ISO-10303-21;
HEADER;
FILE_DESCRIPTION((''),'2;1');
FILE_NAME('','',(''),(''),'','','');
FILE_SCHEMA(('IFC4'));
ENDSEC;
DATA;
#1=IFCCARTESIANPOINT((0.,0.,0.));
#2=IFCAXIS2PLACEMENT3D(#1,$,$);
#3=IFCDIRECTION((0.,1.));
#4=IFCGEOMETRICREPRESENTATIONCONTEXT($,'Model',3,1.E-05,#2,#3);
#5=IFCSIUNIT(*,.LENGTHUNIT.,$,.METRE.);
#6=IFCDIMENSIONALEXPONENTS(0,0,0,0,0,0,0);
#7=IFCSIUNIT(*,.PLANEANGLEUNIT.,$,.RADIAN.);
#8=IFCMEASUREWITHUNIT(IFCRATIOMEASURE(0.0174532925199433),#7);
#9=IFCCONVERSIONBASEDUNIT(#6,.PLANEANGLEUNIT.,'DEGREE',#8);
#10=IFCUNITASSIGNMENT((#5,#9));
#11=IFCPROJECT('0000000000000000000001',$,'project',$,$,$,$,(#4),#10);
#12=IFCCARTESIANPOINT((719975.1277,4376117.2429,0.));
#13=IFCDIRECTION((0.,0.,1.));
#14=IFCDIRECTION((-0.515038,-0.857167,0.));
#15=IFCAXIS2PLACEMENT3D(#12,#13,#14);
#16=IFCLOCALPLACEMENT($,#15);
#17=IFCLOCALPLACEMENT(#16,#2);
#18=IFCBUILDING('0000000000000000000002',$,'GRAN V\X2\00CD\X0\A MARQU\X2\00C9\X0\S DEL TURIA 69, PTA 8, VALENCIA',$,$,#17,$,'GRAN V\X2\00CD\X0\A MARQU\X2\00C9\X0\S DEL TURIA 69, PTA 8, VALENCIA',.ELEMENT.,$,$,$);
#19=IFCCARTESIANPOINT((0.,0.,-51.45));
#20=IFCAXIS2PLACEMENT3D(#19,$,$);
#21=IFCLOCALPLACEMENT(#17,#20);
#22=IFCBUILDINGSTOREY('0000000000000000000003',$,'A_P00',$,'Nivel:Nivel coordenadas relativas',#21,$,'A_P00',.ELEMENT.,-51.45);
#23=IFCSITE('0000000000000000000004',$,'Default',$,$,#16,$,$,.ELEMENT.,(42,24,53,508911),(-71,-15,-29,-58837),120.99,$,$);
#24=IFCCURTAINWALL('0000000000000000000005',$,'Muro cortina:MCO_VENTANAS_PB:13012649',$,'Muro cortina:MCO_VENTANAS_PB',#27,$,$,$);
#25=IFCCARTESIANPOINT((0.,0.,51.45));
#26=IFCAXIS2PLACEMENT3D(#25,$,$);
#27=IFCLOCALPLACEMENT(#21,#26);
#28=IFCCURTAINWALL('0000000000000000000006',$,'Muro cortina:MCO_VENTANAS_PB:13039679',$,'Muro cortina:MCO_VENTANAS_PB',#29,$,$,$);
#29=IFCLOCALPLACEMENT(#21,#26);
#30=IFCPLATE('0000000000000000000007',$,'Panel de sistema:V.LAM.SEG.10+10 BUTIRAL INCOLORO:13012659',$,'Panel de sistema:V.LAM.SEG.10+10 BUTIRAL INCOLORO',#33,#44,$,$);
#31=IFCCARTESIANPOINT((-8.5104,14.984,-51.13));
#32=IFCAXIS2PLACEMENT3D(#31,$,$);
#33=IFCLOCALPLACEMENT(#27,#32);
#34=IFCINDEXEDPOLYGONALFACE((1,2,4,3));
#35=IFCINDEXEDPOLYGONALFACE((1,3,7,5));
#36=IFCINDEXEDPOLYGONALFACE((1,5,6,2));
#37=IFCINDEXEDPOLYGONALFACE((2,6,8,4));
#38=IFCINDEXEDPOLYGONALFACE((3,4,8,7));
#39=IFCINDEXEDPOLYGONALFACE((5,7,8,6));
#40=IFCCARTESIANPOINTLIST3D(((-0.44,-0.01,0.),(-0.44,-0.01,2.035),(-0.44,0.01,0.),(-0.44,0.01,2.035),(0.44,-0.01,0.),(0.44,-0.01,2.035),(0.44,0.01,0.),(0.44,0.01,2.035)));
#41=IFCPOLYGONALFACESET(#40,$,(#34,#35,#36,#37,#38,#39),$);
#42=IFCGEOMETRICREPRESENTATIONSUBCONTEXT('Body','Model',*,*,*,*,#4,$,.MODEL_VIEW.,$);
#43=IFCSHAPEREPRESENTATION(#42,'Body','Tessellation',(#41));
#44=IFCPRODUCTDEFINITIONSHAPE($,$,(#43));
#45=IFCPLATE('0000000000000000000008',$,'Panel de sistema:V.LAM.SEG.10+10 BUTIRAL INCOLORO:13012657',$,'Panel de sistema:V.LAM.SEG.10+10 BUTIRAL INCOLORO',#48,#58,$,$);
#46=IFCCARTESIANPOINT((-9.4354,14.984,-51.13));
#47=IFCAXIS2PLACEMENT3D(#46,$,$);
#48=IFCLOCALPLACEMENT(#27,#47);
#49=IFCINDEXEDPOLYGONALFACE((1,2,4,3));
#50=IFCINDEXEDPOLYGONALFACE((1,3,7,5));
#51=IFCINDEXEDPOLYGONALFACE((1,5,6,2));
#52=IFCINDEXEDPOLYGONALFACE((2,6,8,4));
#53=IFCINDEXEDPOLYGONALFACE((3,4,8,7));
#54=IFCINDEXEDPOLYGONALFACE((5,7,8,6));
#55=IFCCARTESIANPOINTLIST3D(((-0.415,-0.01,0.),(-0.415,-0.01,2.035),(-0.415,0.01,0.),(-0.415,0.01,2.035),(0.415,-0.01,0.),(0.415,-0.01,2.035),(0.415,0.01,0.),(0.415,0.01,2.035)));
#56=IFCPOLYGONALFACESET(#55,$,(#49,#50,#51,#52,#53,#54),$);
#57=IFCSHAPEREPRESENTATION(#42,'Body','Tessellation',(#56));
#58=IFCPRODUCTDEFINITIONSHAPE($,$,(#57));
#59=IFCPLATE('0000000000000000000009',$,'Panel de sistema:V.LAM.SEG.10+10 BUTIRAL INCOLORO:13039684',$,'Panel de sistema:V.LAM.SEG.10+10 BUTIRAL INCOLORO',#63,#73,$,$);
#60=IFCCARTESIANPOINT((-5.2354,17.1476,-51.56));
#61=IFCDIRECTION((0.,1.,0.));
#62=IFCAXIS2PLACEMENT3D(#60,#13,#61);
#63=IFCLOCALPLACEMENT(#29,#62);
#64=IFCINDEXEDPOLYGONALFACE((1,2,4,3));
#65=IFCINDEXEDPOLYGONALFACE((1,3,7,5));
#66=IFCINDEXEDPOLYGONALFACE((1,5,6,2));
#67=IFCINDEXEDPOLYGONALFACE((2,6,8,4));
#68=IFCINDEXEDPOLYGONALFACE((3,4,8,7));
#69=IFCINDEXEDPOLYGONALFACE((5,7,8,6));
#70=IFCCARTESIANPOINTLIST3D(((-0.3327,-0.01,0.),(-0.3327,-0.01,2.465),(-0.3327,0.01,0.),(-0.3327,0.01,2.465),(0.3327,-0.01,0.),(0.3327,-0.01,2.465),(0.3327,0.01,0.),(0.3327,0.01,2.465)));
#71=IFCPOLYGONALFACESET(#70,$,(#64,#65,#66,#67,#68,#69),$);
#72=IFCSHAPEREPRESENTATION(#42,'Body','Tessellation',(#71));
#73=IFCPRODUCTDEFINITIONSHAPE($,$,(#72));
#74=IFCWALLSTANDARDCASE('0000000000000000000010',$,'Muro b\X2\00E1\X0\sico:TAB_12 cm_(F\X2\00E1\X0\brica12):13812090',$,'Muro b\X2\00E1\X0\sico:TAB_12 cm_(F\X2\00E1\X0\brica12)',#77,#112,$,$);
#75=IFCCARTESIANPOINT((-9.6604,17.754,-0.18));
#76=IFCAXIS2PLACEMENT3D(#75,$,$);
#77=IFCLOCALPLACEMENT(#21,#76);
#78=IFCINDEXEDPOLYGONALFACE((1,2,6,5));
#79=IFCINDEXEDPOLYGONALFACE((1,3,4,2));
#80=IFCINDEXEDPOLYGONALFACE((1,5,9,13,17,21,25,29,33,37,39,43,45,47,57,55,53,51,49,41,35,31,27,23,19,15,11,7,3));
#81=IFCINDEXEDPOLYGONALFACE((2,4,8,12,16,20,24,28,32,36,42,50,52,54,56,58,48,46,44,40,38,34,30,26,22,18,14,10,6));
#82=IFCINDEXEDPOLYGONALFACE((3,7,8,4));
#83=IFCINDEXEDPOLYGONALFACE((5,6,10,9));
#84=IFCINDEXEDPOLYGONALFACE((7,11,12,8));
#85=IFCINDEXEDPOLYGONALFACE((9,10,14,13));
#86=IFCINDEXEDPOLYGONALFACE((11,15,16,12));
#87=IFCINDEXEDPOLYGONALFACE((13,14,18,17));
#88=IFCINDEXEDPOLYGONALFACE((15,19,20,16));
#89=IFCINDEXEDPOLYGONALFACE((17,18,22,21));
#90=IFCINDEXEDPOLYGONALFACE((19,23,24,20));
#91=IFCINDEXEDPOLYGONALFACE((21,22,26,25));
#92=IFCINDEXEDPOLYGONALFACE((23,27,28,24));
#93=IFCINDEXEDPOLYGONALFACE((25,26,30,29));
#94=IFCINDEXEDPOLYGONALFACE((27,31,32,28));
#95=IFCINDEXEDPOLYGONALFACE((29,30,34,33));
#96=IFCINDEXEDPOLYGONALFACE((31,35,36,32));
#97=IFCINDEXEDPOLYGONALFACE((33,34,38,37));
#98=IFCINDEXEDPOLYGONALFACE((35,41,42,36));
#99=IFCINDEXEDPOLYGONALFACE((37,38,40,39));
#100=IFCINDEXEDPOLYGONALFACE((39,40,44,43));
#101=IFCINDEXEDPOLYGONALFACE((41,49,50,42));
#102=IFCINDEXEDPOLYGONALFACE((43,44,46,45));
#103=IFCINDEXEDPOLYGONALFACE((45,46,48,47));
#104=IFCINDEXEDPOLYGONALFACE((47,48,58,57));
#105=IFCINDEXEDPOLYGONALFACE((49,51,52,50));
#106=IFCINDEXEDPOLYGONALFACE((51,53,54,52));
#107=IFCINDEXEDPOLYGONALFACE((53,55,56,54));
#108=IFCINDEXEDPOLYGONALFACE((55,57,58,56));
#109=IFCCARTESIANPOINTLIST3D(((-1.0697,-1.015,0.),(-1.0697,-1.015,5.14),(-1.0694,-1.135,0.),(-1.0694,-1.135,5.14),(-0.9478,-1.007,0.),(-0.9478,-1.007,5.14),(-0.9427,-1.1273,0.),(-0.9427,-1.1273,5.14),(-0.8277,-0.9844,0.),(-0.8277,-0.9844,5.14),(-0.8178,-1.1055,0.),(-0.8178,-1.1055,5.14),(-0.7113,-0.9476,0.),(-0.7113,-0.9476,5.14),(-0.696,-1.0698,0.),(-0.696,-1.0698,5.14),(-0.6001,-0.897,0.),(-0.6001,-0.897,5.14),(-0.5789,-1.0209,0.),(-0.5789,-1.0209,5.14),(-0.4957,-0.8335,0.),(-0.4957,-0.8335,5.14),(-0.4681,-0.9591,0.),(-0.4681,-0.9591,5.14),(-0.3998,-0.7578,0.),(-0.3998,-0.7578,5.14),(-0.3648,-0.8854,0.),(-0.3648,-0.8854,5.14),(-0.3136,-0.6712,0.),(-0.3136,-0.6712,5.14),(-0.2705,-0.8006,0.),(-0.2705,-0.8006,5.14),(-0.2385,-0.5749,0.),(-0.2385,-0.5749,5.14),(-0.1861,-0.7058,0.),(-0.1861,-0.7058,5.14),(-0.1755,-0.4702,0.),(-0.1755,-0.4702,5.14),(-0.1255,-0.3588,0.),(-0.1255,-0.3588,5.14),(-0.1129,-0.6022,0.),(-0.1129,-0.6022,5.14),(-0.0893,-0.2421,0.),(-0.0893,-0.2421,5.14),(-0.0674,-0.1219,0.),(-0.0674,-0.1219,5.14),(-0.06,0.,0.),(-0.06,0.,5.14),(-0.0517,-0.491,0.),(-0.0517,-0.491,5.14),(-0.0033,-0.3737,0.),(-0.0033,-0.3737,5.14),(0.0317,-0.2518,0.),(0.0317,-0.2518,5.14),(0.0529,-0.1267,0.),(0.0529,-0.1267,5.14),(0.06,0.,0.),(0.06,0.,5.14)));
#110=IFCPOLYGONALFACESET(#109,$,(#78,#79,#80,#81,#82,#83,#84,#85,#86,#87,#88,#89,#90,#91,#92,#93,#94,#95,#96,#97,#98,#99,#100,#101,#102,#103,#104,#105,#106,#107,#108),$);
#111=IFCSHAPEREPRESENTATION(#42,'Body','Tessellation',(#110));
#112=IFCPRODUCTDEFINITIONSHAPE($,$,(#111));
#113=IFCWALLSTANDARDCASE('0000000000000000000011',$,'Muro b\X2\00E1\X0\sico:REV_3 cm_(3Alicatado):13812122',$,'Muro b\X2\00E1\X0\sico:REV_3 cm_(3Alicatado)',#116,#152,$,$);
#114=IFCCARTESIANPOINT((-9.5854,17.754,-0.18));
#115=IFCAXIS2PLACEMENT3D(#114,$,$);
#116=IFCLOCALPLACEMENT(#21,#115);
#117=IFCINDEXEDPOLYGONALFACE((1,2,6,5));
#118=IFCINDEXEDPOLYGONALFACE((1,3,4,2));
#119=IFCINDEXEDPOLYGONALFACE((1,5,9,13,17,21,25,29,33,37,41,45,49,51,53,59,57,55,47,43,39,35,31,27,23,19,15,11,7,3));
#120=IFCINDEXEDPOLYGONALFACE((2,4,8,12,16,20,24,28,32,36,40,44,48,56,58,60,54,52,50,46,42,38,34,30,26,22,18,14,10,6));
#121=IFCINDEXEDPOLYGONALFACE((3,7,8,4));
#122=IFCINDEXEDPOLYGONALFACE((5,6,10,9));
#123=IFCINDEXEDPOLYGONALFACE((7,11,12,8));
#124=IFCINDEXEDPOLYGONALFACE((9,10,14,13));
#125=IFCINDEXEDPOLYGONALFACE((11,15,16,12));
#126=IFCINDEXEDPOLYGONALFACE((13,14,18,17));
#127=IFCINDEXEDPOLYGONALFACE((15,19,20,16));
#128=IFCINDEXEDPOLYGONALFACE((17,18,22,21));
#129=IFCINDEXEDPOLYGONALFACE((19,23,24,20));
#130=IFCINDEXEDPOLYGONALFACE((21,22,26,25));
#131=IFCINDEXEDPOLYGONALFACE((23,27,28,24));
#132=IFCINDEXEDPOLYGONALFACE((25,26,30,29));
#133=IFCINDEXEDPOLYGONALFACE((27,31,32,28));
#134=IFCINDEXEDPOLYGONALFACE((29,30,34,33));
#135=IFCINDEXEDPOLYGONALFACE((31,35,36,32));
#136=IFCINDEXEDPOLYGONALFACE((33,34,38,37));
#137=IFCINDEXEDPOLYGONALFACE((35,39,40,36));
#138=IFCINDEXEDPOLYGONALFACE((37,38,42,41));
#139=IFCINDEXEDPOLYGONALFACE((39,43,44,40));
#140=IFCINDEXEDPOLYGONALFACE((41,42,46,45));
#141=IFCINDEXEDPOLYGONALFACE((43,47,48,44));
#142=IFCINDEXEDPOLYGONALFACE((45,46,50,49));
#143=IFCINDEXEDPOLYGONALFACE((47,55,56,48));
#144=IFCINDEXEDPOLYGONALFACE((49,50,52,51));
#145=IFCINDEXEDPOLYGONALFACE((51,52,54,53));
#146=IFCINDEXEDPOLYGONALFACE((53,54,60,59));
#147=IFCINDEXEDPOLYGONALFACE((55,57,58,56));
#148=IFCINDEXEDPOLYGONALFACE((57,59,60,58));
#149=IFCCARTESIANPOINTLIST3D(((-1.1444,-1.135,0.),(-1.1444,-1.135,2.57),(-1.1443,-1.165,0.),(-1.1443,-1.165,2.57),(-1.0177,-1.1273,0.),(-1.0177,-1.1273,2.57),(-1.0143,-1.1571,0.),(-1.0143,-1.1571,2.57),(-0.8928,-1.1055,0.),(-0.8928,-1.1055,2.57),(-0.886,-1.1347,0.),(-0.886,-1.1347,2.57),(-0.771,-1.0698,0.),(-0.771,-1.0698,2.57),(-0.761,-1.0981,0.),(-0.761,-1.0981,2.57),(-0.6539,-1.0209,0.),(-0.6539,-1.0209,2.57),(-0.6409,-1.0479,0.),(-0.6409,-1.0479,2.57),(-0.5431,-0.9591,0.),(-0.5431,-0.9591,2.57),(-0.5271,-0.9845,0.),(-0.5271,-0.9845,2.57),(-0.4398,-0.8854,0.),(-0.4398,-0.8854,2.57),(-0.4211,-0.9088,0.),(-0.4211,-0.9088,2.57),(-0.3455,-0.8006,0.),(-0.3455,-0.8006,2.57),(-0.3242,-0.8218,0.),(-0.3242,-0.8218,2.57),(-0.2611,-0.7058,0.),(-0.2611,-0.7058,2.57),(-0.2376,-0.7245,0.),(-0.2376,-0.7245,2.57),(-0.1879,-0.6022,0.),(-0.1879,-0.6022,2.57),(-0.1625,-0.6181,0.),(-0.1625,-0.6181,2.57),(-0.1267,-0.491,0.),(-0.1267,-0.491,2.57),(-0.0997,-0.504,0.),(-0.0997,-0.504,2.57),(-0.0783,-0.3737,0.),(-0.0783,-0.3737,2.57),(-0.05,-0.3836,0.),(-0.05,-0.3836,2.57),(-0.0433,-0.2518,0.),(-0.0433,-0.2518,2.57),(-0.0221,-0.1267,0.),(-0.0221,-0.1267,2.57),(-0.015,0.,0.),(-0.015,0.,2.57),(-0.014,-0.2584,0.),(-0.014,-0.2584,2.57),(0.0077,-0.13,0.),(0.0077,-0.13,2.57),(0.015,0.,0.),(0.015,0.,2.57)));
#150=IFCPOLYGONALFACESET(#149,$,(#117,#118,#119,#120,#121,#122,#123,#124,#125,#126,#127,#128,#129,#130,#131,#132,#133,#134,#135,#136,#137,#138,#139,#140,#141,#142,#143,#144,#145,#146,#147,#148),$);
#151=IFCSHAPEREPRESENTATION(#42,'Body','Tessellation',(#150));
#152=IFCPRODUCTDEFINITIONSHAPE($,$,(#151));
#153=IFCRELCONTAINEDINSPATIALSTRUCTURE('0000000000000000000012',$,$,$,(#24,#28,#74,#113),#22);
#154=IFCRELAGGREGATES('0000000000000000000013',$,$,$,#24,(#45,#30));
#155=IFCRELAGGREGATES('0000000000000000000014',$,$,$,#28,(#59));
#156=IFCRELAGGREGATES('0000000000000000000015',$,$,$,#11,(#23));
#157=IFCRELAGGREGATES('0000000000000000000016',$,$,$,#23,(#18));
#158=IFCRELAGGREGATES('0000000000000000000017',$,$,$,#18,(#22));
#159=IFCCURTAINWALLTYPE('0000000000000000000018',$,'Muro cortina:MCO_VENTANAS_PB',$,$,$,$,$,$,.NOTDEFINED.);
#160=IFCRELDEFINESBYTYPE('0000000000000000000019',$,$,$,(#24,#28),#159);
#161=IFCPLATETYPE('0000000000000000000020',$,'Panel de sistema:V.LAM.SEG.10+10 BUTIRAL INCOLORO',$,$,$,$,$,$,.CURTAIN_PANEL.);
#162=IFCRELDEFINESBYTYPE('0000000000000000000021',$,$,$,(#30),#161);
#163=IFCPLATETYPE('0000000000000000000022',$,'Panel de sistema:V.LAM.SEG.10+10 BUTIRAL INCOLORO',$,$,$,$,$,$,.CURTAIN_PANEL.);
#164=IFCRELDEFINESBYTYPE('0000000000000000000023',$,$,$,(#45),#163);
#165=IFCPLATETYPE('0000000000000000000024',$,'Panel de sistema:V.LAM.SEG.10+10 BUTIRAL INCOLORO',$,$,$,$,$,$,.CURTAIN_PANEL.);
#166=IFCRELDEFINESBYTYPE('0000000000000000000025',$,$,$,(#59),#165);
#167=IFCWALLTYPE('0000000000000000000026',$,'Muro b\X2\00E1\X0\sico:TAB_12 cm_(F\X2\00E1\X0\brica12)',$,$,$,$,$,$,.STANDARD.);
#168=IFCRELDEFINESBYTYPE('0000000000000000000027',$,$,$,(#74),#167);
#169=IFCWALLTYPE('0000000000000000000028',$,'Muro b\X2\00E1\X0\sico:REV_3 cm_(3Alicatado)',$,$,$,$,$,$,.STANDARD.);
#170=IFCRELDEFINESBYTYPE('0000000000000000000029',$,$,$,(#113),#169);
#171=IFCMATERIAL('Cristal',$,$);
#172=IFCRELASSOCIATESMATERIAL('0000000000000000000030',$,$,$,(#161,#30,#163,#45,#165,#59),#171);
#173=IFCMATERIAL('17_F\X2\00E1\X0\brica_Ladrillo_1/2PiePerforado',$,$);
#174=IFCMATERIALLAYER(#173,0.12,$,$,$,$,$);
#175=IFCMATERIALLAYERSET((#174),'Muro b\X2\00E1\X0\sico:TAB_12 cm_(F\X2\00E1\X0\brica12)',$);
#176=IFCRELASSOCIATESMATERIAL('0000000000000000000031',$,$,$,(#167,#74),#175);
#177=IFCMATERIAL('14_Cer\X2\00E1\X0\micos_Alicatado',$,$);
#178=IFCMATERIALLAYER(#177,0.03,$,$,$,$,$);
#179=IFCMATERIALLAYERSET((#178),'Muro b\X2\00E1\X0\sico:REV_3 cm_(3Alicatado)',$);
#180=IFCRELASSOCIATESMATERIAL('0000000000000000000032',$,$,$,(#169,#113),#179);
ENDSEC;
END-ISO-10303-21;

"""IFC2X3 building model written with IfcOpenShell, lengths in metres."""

from ifc_helpers import new_model, entity, si_unit, converted_unit, direction, frame, frame_2d, origin, origin_2d_with_axis, place, context, subcontext, project, spatial, polyline, circle_curve, parameter, trimmed, segment, composite_curve, rectangle, outline, extrude, source, transform, mapped, material, layer, layer_set, layer_usage, type_object, type_shapes, element, aggregate, save


model = new_model("IFC2X3")

# Units and contexts
model_context = context("Model", 3, precision=1e-05, world=origin(), true_north=direction((0.0, 1.0)))
body_context = subcontext(model_context, "Body", "Model", "MODEL_VIEW")
ifc_project = project(units=[si_unit("LENGTHUNIT", "METRE"), converted_unit("PLANEANGLEUNIT", "DEGREE", entity("IfcRatioMeasure", 0.0174532925199433), si_unit("PLANEANGLEUNIT", "RADIAN"), dimensions=[0, 0, 0, 0, 0, 0, 0])], contexts=[model_context])

# Site, building, storey
site_placement = place(None, frame((719975.1277, 4376117.2429, 0.0), z_axis=(0.0, 0.0, 1.0), x_axis=(-0.515038, -0.857167, 0.0)))
site = spatial("IfcSite", under=ifc_project, at=site_placement, Name="Default", CompositionType="ELEMENT", RefLatitude=(42, 24, 53, 508911), RefLongitude=(-71, -15, -29, -58837), RefElevation=120.99)
building_placement = place(site_placement, origin())
building = spatial("IfcBuilding", under=site, at=building_placement, Name="GRAN VÍA MARQUÉS DEL TURIA 69, PTA 8, VALENCIA", LongName="GRAN VÍA MARQUÉS DEL TURIA 69, PTA 8, VALENCIA", CompositionType="ELEMENT")
storey_placement = place(building_placement, frame((0.0, 0.0, -51.45)))
storey = spatial("IfcBuildingStorey", under=building, at=storey_placement, Name="A_P00", ObjectType="Nivel:Nivel coordenadas relativas", LongName="A_P00", CompositionType="ELEMENT", Elevation=-51.45)

# Curtain walls
curtain_wall_type_1 = type_object("IfcCurtainWallType", Name="Muro cortina:MCO_VENTANAS_PB", PredefinedType="NOTDEFINED")
curtain_wall_1_placement = place(storey_placement, frame((0.0, 0.0, 51.45)))
curtain_wall_1 = element("IfcCurtainWall", 1, at=curtain_wall_1_placement, inside=storey, type_object=curtain_wall_type_1, Name="Muro cortina:MCO_VENTANAS_PB:13012649", ObjectType="Muro cortina:MCO_VENTANAS_PB")
curtain_wall_2_placement = place(storey_placement, frame((0.0, 0.0, 51.45)))
curtain_wall_2 = element("IfcCurtainWall", 2, at=curtain_wall_2_placement, inside=storey, type_object=curtain_wall_type_1, Name="Muro cortina:MCO_VENTANAS_PB:13039679", ObjectType="Muro cortina:MCO_VENTANAS_PB")

# Plates
ifc_material_1 = material(Name="Cristal")
plate_type_1 = type_object("IfcPlateType", Name="Panel de sistema:V.LAM.SEG.10+10 BUTIRAL INCOLORO", PredefinedType="CURTAIN_PANEL", material=ifc_material_1)
shared_shape_1 = source(origin(), body_context, "Body", "SweptSolid", [
    extrude(rectangle(XDim=0.02, YDim=0.88, at=origin_2d_with_axis()), frame((0.0, 0.0, 0.0), z_axis=(0.0, 0.0, 1.0), x_axis=(0.0, 1.0, 0.0)), (0.0, 0.0, 1.0), 2.035),
])
type_shapes(plate_type_1, [shared_shape_1])
plate_1_placement = place(curtain_wall_1_placement, frame((-8.5104, 14.984, -51.13)))
plate_1 = element("IfcPlate", 3, at=plate_1_placement, type_object=plate_type_1, material=ifc_material_1, Name="Panel de sistema:V.LAM.SEG.10+10 BUTIRAL INCOLORO:13012659", ObjectType="Panel de sistema:V.LAM.SEG.10+10 BUTIRAL INCOLORO", context=body_context, shape_type="MappedRepresentation", body=[
    mapped(shared_shape_1, transform((0.0, 0.0, 0.0), scale=1.0)),
])
plate_type_2 = type_object("IfcPlateType", Name="Panel de sistema:V.LAM.SEG.10+10 BUTIRAL INCOLORO", PredefinedType="CURTAIN_PANEL", material=ifc_material_1)
shared_shape_2 = source(origin(), body_context, "Body", "SweptSolid", [
    extrude(rectangle(XDim=0.02, YDim=0.83, at=origin_2d_with_axis()), frame((0.0, 0.0, 0.0), z_axis=(0.0, 0.0, 1.0), x_axis=(0.0, 1.0, 0.0)), (0.0, 0.0, 1.0), 2.035),
])
type_shapes(plate_type_2, [shared_shape_2])
plate_2_placement = place(curtain_wall_1_placement, frame((-9.4354, 14.984, -51.13)))
plate_2 = element("IfcPlate", 4, at=plate_2_placement, type_object=plate_type_2, material=ifc_material_1, Name="Panel de sistema:V.LAM.SEG.10+10 BUTIRAL INCOLORO:13012657", ObjectType="Panel de sistema:V.LAM.SEG.10+10 BUTIRAL INCOLORO", context=body_context, shape_type="MappedRepresentation", body=[
    mapped(shared_shape_2, transform((0.0, 0.0, 0.0), scale=1.0)),
])
aggregate(curtain_wall_1, [plate_2, plate_1])
plate_type_3 = type_object("IfcPlateType", Name="Panel de sistema:V.LAM.SEG.10+10 BUTIRAL INCOLORO", PredefinedType="CURTAIN_PANEL", material=ifc_material_1)
shared_shape_3 = source(origin(), body_context, "Body", "SweptSolid", [
    extrude(rectangle(XDim=0.02, YDim=0.6654, at=origin_2d_with_axis()), frame((0.0, 0.0, 0.0), z_axis=(0.0, 0.0, 1.0), x_axis=(0.0, 1.0, 0.0)), (0.0, 0.0, 1.0), 2.465),
])
type_shapes(plate_type_3, [shared_shape_3])
plate_3_placement = place(curtain_wall_2_placement, frame((-5.2354, 17.1476, -51.56), z_axis=(0.0, 0.0, 1.0), x_axis=(0.0, 1.0, 0.0)))
plate_3 = element("IfcPlate", 5, at=plate_3_placement, type_object=plate_type_3, material=ifc_material_1, Name="Panel de sistema:V.LAM.SEG.10+10 BUTIRAL INCOLORO:13039684", ObjectType="Panel de sistema:V.LAM.SEG.10+10 BUTIRAL INCOLORO", context=body_context, shape_type="MappedRepresentation", body=[
    mapped(shared_shape_3, transform((0.0, 0.0, 0.0), scale=1.0)),
])
aggregate(curtain_wall_2, [plate_3])

# Shared definitions
ifc_material_2 = material(Name="17_Fábrica_Ladrillo_1/2PiePerforado")
ifc_layer_1 = layer(ifc_material_2, 0.12)
ifc_layer_set_1 = layer_set([ifc_layer_1], Name="Muro básico:TAB_12 cm_(Fábrica12)")
wall_type_1 = type_object("IfcWallType", Name="Muro básico:TAB_12 cm_(Fábrica12)", PredefinedType="STANDARD", material=ifc_layer_set_1)

# Wall
ifc_layer_usage_1 = layer_usage(ifc_layer_set_1, "AXIS2", "NEGATIVE", 0.06)
wall_1_placement = place(storey_placement, frame((-9.6604, 17.754, -0.18)))
element("IfcWallStandardCase", 6, at=wall_1_placement, inside=storey, type_object=wall_type_1, material=ifc_layer_usage_1, Name="Muro básico:TAB_12 cm_(Fábrica12):13812090", ObjectType="Muro básico:TAB_12 cm_(Fábrica12)", context=body_context, shape_type="SweptSolid", body=[
    extrude(outline(composite_curve([segment(trimmed(circle_curve(frame_2d((-1.075, 0.0), x_axis=(1.0, 0.0)), 1.135), [parameter(270.283352)], [parameter(360.0)], True, "PARAMETER"), True, "CONTINUOUS"), segment(polyline([(0.06, 0.0), (-0.06, 0.0)]), True, "CONTINUOUS"), segment(trimmed(circle_curve(frame_2d((-1.075, 0.0), x_axis=(1.0, 0.0)), 1.015), [parameter(270.299635)], [parameter(360.0)], True, "PARAMETER"), False, "CONTINUOUS"), segment(polyline([(-1.0697, -1.015), (-1.0694, -1.135)]), True, "CONTINUOUS")], self_intersect=False)), origin(), (0.0, 0.0, 1.0), 5.14),
])

# Shared definitions
ifc_material_3 = material(Name="14_Cerámicos_Alicatado")
ifc_layer_2 = layer(ifc_material_3, 0.03)
ifc_layer_set_2 = layer_set([ifc_layer_2], Name="Muro básico:REV_3 cm_(3Alicatado)")
wall_type_2 = type_object("IfcWallType", Name="Muro básico:REV_3 cm_(3Alicatado)", PredefinedType="STANDARD", material=ifc_layer_set_2)

# Wall
ifc_layer_usage_2 = layer_usage(ifc_layer_set_2, "AXIS2", "NEGATIVE", 0.015)
wall_2_placement = place(storey_placement, frame((-9.5854, 17.754, -0.18)))
element("IfcWallStandardCase", 7, at=wall_2_placement, inside=storey, type_object=wall_type_2, material=ifc_layer_usage_2, Name="Muro básico:REV_3 cm_(3Alicatado):13812122", ObjectType="Muro básico:REV_3 cm_(3Alicatado)", context=body_context, shape_type="SweptSolid", body=[
    extrude(outline(composite_curve([segment(trimmed(circle_curve(frame_2d((-1.15, 0.0), x_axis=(1.0, 0.0)), 1.165), [parameter(270.27968)], [parameter(360.0)], True, "PARAMETER"), True, "CONTINUOUS"), segment(polyline([(0.015, 0.0), (-0.015, 0.0)]), True, "CONTINUOUS"), segment(trimmed(circle_curve(frame_2d((-1.15, 0.0), x_axis=(1.0, 0.0)), 1.135), [parameter(270.283352)], [parameter(360.0)], True, "PARAMETER"), False, "CONTINUOUS"), segment(polyline([(-1.1444, -1.135), (-1.1443, -1.165)]), True, "CONTINUOUS")], self_intersect=False)), origin(), (0.0, 0.0, 1.0), 2.57),
])

save(model, "model.ifc")
